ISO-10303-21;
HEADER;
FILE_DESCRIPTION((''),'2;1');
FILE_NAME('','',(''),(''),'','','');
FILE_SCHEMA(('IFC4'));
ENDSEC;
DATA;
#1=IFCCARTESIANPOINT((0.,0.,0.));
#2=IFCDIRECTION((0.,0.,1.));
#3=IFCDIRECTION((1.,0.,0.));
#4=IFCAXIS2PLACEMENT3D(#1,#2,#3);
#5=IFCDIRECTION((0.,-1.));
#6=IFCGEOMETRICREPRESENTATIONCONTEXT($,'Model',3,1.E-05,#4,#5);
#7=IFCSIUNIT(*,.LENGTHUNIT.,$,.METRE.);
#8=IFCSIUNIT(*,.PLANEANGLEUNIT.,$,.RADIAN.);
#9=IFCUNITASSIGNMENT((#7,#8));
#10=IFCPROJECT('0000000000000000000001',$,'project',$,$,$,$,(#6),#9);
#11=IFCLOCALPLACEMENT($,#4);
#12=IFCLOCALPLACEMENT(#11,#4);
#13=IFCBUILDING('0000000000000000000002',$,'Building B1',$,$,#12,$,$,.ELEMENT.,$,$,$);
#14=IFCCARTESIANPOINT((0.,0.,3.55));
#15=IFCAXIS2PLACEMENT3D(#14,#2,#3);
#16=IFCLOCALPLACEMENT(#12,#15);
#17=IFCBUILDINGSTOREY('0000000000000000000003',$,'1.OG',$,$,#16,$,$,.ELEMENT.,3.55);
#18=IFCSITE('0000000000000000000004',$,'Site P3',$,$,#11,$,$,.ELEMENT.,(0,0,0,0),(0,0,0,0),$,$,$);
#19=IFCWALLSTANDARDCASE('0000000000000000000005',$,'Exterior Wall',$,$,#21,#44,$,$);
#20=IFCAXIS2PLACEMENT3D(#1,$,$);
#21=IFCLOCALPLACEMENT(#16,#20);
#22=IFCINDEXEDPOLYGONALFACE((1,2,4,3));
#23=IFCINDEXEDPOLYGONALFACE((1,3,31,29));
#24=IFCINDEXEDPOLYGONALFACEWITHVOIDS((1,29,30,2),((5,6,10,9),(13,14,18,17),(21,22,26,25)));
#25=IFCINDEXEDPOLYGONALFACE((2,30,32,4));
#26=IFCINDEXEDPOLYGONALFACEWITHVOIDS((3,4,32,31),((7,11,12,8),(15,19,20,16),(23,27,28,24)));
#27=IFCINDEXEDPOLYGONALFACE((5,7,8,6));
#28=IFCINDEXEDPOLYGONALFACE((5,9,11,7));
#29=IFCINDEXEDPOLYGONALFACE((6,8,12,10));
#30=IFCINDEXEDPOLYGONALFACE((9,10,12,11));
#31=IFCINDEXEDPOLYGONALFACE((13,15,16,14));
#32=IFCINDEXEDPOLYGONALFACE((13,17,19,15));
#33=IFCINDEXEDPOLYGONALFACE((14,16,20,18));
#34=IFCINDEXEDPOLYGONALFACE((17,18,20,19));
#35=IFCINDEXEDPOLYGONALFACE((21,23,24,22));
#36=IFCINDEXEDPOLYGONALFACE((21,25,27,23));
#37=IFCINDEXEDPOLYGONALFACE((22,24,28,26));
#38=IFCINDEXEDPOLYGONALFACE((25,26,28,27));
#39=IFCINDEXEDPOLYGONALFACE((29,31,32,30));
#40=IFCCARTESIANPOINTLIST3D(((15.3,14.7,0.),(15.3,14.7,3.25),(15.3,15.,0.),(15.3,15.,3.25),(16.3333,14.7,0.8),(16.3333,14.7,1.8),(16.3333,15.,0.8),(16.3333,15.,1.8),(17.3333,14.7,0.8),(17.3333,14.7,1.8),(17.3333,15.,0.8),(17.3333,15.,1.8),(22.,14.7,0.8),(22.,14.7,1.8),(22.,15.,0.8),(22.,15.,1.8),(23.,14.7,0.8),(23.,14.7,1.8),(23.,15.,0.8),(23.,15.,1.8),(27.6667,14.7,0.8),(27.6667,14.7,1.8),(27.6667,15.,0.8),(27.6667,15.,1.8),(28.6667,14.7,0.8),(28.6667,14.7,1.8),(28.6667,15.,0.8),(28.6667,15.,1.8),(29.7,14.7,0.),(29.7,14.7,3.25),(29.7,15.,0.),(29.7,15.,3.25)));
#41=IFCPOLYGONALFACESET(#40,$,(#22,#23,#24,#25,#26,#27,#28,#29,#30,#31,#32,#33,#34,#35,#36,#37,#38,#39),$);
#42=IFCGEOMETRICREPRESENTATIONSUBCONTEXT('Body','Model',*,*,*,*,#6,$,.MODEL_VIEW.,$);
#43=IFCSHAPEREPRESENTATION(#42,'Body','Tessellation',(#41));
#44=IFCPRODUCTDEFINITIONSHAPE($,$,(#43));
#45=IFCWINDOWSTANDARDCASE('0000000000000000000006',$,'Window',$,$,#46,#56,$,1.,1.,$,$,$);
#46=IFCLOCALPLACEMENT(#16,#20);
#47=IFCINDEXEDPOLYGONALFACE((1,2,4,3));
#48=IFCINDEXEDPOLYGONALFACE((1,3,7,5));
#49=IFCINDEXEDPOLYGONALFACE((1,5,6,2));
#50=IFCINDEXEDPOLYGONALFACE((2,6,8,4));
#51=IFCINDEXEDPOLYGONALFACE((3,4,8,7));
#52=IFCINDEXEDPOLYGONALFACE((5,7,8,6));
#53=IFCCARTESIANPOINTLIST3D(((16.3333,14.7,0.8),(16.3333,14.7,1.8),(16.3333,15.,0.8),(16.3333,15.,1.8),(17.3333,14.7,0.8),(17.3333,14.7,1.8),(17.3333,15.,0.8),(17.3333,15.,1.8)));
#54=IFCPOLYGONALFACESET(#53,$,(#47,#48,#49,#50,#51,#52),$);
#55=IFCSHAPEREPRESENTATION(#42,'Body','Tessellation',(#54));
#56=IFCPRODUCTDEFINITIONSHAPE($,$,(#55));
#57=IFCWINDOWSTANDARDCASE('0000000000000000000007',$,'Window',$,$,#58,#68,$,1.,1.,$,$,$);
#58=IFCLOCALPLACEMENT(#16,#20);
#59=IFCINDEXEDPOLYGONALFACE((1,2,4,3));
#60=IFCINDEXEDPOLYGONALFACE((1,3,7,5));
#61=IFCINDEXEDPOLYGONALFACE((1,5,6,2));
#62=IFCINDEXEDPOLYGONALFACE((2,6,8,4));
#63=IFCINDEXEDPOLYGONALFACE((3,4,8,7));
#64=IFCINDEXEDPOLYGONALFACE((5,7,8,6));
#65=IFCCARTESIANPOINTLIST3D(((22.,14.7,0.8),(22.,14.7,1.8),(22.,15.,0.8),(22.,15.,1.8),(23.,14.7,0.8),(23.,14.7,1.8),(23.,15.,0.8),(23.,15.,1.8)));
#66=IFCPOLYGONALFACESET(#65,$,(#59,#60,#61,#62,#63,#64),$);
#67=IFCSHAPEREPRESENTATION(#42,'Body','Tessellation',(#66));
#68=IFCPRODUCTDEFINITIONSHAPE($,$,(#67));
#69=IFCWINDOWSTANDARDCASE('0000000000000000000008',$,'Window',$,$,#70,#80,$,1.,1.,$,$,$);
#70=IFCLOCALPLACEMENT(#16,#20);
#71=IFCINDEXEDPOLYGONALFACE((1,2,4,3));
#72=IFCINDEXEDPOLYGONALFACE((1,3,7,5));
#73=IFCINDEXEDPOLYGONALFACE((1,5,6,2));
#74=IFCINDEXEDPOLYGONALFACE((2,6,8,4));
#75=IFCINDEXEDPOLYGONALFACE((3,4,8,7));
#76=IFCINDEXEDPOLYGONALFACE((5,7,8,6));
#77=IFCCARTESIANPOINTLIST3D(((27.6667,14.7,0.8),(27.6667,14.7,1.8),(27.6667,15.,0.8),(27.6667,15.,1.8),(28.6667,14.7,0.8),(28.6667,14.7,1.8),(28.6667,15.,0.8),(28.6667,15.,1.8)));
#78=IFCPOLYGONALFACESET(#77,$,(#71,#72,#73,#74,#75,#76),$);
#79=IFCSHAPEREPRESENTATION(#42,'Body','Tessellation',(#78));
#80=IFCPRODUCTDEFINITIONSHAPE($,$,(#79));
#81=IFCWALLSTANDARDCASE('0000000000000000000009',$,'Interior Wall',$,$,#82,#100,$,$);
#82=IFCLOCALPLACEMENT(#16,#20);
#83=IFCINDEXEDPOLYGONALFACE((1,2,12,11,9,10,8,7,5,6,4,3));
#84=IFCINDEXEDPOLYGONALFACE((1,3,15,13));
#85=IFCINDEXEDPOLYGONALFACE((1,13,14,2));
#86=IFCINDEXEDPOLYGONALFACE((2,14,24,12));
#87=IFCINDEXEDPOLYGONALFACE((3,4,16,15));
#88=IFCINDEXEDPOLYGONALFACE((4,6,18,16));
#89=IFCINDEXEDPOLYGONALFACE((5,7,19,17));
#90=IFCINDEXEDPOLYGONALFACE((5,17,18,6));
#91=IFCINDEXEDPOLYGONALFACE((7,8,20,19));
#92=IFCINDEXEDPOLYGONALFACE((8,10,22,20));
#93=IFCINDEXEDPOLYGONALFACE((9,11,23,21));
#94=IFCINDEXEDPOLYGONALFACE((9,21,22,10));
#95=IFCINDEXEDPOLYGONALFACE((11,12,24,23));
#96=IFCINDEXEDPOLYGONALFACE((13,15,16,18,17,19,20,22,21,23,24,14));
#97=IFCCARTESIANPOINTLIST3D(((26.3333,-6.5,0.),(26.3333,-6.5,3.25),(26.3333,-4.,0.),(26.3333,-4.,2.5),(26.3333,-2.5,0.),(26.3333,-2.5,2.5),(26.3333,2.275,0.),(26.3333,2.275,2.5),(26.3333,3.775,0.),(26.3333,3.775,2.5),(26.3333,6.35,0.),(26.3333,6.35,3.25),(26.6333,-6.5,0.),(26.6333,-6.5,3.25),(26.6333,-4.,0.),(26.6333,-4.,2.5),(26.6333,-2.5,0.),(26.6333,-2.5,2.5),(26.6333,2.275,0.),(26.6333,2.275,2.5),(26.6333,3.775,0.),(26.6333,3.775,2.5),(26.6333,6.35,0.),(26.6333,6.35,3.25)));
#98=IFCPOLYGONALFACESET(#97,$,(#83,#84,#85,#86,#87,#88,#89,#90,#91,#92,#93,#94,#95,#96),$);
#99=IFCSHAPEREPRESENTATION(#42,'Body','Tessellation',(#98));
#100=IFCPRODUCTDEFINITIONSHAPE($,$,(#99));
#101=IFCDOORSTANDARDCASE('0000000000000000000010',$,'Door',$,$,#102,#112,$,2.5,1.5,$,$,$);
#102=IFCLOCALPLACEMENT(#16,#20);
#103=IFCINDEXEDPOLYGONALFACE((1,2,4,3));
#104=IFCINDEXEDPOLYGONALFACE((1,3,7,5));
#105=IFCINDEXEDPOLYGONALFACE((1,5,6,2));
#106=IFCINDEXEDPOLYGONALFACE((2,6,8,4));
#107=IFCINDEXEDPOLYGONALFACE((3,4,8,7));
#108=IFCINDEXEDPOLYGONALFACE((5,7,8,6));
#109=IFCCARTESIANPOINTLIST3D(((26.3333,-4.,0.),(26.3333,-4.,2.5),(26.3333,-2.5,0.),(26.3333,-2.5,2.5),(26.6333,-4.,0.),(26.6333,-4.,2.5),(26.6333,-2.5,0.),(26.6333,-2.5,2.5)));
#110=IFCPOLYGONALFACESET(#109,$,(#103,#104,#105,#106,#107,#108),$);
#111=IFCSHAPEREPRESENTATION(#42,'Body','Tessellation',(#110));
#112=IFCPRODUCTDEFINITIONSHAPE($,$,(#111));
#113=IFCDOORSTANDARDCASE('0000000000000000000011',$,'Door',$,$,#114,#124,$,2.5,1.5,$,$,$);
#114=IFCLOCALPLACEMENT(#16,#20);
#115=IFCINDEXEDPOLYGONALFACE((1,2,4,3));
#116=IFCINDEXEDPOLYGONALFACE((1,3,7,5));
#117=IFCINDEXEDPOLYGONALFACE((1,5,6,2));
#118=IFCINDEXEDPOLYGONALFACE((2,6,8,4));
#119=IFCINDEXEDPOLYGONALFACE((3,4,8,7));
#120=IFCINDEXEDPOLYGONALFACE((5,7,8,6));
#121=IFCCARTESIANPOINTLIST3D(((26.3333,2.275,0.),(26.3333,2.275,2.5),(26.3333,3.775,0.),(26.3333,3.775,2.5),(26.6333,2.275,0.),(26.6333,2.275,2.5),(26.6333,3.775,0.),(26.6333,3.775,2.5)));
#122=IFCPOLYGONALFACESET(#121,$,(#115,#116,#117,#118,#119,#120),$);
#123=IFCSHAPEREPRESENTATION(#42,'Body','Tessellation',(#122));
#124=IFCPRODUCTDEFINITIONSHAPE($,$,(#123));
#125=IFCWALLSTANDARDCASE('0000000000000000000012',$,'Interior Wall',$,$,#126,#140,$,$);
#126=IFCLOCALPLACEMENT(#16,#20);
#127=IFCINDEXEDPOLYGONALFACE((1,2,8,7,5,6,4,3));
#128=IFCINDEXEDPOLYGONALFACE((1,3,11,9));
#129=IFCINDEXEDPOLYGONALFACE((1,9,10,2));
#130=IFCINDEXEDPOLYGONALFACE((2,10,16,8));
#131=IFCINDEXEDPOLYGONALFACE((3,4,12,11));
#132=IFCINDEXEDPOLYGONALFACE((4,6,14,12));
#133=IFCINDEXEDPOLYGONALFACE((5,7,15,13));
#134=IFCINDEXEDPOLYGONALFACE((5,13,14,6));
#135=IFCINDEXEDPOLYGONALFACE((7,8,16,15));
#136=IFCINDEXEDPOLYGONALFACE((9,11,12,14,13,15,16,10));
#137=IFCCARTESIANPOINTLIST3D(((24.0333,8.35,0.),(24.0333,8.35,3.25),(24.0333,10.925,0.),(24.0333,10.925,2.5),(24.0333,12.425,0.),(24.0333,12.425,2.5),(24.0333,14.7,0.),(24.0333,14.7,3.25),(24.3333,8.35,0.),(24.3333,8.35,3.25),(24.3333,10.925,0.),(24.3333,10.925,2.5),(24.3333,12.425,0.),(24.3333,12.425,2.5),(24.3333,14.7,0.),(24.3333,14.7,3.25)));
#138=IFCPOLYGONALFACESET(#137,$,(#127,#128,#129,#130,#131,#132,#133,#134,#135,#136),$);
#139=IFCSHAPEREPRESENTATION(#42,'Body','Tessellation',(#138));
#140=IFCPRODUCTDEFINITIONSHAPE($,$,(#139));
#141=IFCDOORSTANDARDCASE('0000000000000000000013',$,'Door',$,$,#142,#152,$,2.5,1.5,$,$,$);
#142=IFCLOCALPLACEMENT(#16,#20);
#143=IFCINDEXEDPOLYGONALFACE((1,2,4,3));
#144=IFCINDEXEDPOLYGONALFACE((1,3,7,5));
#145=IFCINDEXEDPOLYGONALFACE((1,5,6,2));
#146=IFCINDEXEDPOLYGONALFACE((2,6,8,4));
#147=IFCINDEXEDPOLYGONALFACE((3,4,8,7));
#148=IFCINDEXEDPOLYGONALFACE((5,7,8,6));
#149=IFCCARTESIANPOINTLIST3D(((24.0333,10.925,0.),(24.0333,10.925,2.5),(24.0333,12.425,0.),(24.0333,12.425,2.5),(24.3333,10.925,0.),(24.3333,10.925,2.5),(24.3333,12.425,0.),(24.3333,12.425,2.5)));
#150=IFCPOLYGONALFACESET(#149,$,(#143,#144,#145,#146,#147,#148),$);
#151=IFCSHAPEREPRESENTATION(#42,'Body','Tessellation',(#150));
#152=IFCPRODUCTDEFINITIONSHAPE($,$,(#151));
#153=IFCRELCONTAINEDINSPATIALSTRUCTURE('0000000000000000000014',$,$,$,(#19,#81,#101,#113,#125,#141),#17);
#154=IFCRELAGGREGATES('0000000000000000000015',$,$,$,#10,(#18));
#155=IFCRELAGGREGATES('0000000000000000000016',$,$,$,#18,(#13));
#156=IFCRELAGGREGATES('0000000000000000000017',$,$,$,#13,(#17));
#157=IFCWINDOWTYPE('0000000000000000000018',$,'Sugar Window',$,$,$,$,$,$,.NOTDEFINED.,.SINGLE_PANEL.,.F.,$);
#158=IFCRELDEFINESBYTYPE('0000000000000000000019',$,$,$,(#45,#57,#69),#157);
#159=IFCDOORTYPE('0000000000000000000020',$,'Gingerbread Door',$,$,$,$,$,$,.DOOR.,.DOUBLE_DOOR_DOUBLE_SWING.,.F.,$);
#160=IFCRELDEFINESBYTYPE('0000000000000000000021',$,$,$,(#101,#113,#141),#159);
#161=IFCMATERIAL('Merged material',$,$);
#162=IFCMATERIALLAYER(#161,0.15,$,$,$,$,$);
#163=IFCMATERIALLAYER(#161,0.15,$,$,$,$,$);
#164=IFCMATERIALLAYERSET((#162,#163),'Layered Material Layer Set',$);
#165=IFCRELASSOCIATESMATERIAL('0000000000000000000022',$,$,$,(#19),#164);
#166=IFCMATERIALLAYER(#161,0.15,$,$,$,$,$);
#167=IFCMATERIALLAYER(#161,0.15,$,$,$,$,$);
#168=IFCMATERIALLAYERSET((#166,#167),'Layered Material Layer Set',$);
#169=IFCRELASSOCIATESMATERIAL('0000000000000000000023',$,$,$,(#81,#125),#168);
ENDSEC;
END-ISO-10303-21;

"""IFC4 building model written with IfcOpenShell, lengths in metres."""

from ifc_helpers import new_model, si_unit, direction, frame, origin_with_axes, place, context, subcontext, project, spatial, polyline, outline, extrude, source, transform, mapped, material, layer, layer_set, layer_usage, type_object, element, fill, save


model = new_model("IFC4")

# Units and contexts
model_context = context("Model", 3, precision=1e-05, world=origin_with_axes(), true_north=direction((0.0, -1.0)))
body_context = subcontext(model_context, "Body", "Model", "MODEL_VIEW")
ifc_project = project(units=[si_unit("LENGTHUNIT", "METRE"), si_unit("PLANEANGLEUNIT", "RADIAN")], contexts=[model_context])

# Site, building, storey
site_placement = place(None, origin_with_axes())
site = spatial("IfcSite", under=ifc_project, at=site_placement, Name="Site P3", CompositionType="ELEMENT", RefLatitude=(0, 0, 0, 0), RefLongitude=(0, 0, 0, 0))
building_placement = place(site_placement, origin_with_axes())
building = spatial("IfcBuilding", under=site, at=building_placement, Name="Building B1", CompositionType="ELEMENT")
storey_placement = place(building_placement, frame((0.0, 0.0, 3.55), z_axis=(0.0, 0.0, 1.0), x_axis=(1.0, 0.0, 0.0)))
storey = spatial("IfcBuildingStorey", under=building, at=storey_placement, Name="1.OG", CompositionType="ELEMENT", Elevation=3.55)

# Wall, openings, windows
ifc_material = material(Name="Merged material")
ifc_layer_1 = layer(ifc_material, 0.15)
ifc_layer_2 = layer(ifc_material, 0.15)
ifc_layer_set_1 = layer_set([ifc_layer_1, ifc_layer_2], Name="Layered Material Layer Set")
ifc_layer_usage_1 = layer_usage(ifc_layer_set_1, "AXIS2", "POSITIVE", -0.15)
wall_1_placement = place(storey_placement, frame((29.7, 14.85, 0.0), z_axis=(0.0, 0.0, 1.0), x_axis=(-1.0, 0.0, 0.0)))
wall_1 = element("IfcWallStandardCase", 1, at=wall_1_placement, inside=storey, material=ifc_layer_usage_1, Name="Exterior Wall", context=body_context, shape_type="SweptSolid", body=[
    extrude(outline(polyline([(0.0, 0.15), (14.4, 0.15), (14.4, -0.15), (0.0, -0.15), (0.0, 0.15)])), origin_with_axes(), (0.0, 0.0, 1.0), 3.25),
])
opening_1_placement = place(wall_1_placement, frame((12.3667, 0.0, 0.8), z_axis=(0.0, 0.0, 1.0), x_axis=(1.0, 0.0, 0.0)))
opening_1 = element("IfcOpeningStandardCase", 2, at=opening_1_placement, cuts=wall_1, context=body_context, shape_type="SweptSolid", body=[
    extrude(outline(polyline([(0.0, 0.0), (0.0, 1.0), (1.0, 1.0), (1.0, 0.0), (0.0, 0.0)])), frame((0.0, -0.15, 0.0), z_axis=(0.0, 1.0, 0.0), x_axis=(0.0, 0.0, 1.0)), (0.0, 0.0, 1.0), 0.3),
])
opening_2_placement = place(wall_1_placement, frame((6.7, 0.0, 0.8), z_axis=(0.0, 0.0, 1.0), x_axis=(1.0, 0.0, 0.0)))
opening_2 = element("IfcOpeningStandardCase", 3, at=opening_2_placement, cuts=wall_1, context=body_context, shape_type="SweptSolid", body=[
    extrude(outline(polyline([(0.0, 0.0), (0.0, 1.0), (1.0, 1.0), (1.0, 0.0), (0.0, 0.0)])), frame((0.0, -0.15, 0.0), z_axis=(0.0, 1.0, 0.0), x_axis=(0.0, 0.0, 1.0)), (0.0, 0.0, 1.0), 0.3),
])
opening_3_placement = place(wall_1_placement, frame((1.0333, 0.0, 0.8), z_axis=(0.0, 0.0, 1.0), x_axis=(1.0, 0.0, 0.0)))
opening_3 = element("IfcOpeningStandardCase", 4, at=opening_3_placement, cuts=wall_1, context=body_context, shape_type="SweptSolid", body=[
    extrude(outline(polyline([(0.0, 0.0), (0.0, 1.0), (1.0, 1.0), (1.0, 0.0), (0.0, 0.0)])), frame((0.0, -0.15, 0.0), z_axis=(0.0, 1.0, 0.0), x_axis=(0.0, 0.0, 1.0)), (0.0, 0.0, 1.0), 0.3),
])
window_type = type_object("IfcWindowType", Name="Sugar Window", ParameterTakesPrecedence=False, PartitioningType="SINGLE_PANEL", PredefinedType="NOTDEFINED")
shared_shape_1 = source(origin_with_axes(), body_context, "Body", "SweptSolid", [
    extrude(outline(polyline([(0.0, 0.0), (0.0, 1.0), (1.0, 1.0), (1.0, 0.0), (0.0, 0.0)])), frame((0.0, -0.15, 0.0), z_axis=(0.0, 1.0, 0.0), x_axis=(0.0, 0.0, 1.0)), (0.0, 0.0, 1.0), 0.3),
])
window_1_placement = place(opening_1_placement, origin_with_axes())
window_1 = element("IfcWindowStandardCase", 5, at=window_1_placement, type_object=window_type, Name="Window", OverallHeight=1.0, OverallWidth=1.0, context=body_context, shape_type="MappedRepresentation", body=[
    mapped(shared_shape_1, transform((0.0, 0.0, 0.0))),
])
fill(opening_1, window_1)
window_2_placement = place(opening_2_placement, origin_with_axes())
window_2 = element("IfcWindowStandardCase", 6, at=window_2_placement, type_object=window_type, Name="Window", OverallHeight=1.0, OverallWidth=1.0, context=body_context, shape_type="MappedRepresentation", body=[
    mapped(shared_shape_1, transform((0.0, 0.0, 0.0))),
])
fill(opening_2, window_2)
window_3_placement = place(opening_3_placement, origin_with_axes())
window_3 = element("IfcWindowStandardCase", 7, at=window_3_placement, type_object=window_type, Name="Window", OverallHeight=1.0, OverallWidth=1.0, context=body_context, shape_type="MappedRepresentation", body=[
    mapped(shared_shape_1, transform((0.0, 0.0, 0.0))),
])
fill(opening_3, window_3)

# Wall, openings, doors
ifc_layer_3 = layer(ifc_material, 0.15)
ifc_layer_4 = layer(ifc_material, 0.15)
ifc_layer_set_2 = layer_set([ifc_layer_3, ifc_layer_4], Name="Layered Material Layer Set")
ifc_layer_usage_2 = layer_usage(ifc_layer_set_2, "AXIS2", "POSITIVE", -0.15)
wall_2_placement = place(storey_placement, frame((26.4833, 6.35, 0.0), z_axis=(0.0, 0.0, 1.0), x_axis=(0.0, -1.0, 0.0)))
wall_2 = element("IfcWallStandardCase", 8, at=wall_2_placement, inside=storey, material=ifc_layer_usage_2, Name="Interior Wall", context=body_context, shape_type="SweptSolid", body=[
    extrude(outline(polyline([(0.0, 0.15), (12.85, 0.15), (12.85, -0.15), (0.0, -0.15), (0.0, 0.15)])), origin_with_axes(), (0.0, 0.0, 1.0), 3.25),
])
opening_4_placement = place(wall_2_placement, frame((8.85, 0.0, 0.0), z_axis=(0.0, 0.0, 1.0), x_axis=(1.0, 0.0, 0.0)))
opening_4 = element("IfcOpeningStandardCase", 9, at=opening_4_placement, cuts=wall_2, context=body_context, shape_type="SweptSolid", body=[
    extrude(outline(polyline([(0.0, 0.0), (0.0, 1.5), (2.5, 1.5), (2.5, 0.0), (0.0, 0.0)])), frame((0.0, -0.15, 0.0), z_axis=(0.0, 1.0, 0.0), x_axis=(0.0, 0.0, 1.0)), (0.0, 0.0, 1.0), 0.3),
])
opening_5_placement = place(wall_2_placement, frame((2.575, 0.0, 0.0), z_axis=(0.0, 0.0, 1.0), x_axis=(1.0, 0.0, 0.0)))
opening_5 = element("IfcOpeningStandardCase", 10, at=opening_5_placement, cuts=wall_2, context=body_context, shape_type="SweptSolid", body=[
    extrude(outline(polyline([(0.0, 0.0), (0.0, 1.5), (2.5, 1.5), (2.5, 0.0), (0.0, 0.0)])), frame((0.0, -0.15, 0.0), z_axis=(0.0, 1.0, 0.0), x_axis=(0.0, 0.0, 1.0)), (0.0, 0.0, 1.0), 0.3),
])
door_type = type_object("IfcDoorType", Name="Gingerbread Door", OperationType="DOUBLE_DOOR_DOUBLE_SWING", ParameterTakesPrecedence=False, PredefinedType="DOOR")
shared_shape_2 = source(origin_with_axes(), body_context, "Body", "SweptSolid", [
    extrude(outline(polyline([(0.0, 0.0), (0.0, 1.5), (2.5, 1.5), (2.5, 0.0), (0.0, 0.0)])), frame((0.0, -0.15, 0.0), z_axis=(0.0, 1.0, 0.0), x_axis=(0.0, 0.0, 1.0)), (0.0, 0.0, 1.0), 0.3),
])
door_1_placement = place(opening_4_placement, origin_with_axes())
door_1 = element("IfcDoorStandardCase", 11, at=door_1_placement, inside=storey, type_object=door_type, Name="Door", OverallHeight=2.5, OverallWidth=1.5, context=body_context, shape_type="MappedRepresentation", body=[
    mapped(shared_shape_2, transform((0.0, 0.0, 0.0))),
])
fill(opening_4, door_1)
door_2_placement = place(opening_5_placement, origin_with_axes())
door_2 = element("IfcDoorStandardCase", 12, at=door_2_placement, inside=storey, type_object=door_type, Name="Door", OverallHeight=2.5, OverallWidth=1.5, context=body_context, shape_type="MappedRepresentation", body=[
    mapped(shared_shape_2, transform((0.0, 0.0, 0.0))),
])
fill(opening_5, door_2)

# Wall, opening, door
wall_3_placement = place(storey_placement, frame((24.1833, 14.7, 0.0), z_axis=(0.0, 0.0, 1.0), x_axis=(0.0, -1.0, 0.0)))
wall_3 = element("IfcWallStandardCase", 13, at=wall_3_placement, inside=storey, material=ifc_layer_usage_2, Name="Interior Wall", context=body_context, shape_type="SweptSolid", body=[
    extrude(outline(polyline([(0.0, 0.15), (6.35, 0.15), (6.35, -0.15), (0.0, -0.15), (0.0, 0.15)])), origin_with_axes(), (0.0, 0.0, 1.0), 3.25),
])
opening_6_placement = place(wall_3_placement, frame((2.275, 0.0, 0.0), z_axis=(0.0, 0.0, 1.0), x_axis=(1.0, 0.0, 0.0)))
opening_6 = element("IfcOpeningStandardCase", 14, at=opening_6_placement, cuts=wall_3, context=body_context, shape_type="SweptSolid", body=[
    extrude(outline(polyline([(0.0, 0.0), (0.0, 1.5), (2.5, 1.5), (2.5, 0.0), (0.0, 0.0)])), frame((0.0, -0.15, 0.0), z_axis=(0.0, 1.0, 0.0), x_axis=(0.0, 0.0, 1.0)), (0.0, 0.0, 1.0), 0.3),
])
door_3_placement = place(opening_6_placement, origin_with_axes())
door_3 = element("IfcDoorStandardCase", 15, at=door_3_placement, inside=storey, type_object=door_type, Name="Door", OverallHeight=2.5, OverallWidth=1.5, context=body_context, shape_type="MappedRepresentation", body=[
    mapped(shared_shape_2, transform((0.0, 0.0, 0.0))),
])
fill(opening_6, door_3)

save(model, "model.ifc")
